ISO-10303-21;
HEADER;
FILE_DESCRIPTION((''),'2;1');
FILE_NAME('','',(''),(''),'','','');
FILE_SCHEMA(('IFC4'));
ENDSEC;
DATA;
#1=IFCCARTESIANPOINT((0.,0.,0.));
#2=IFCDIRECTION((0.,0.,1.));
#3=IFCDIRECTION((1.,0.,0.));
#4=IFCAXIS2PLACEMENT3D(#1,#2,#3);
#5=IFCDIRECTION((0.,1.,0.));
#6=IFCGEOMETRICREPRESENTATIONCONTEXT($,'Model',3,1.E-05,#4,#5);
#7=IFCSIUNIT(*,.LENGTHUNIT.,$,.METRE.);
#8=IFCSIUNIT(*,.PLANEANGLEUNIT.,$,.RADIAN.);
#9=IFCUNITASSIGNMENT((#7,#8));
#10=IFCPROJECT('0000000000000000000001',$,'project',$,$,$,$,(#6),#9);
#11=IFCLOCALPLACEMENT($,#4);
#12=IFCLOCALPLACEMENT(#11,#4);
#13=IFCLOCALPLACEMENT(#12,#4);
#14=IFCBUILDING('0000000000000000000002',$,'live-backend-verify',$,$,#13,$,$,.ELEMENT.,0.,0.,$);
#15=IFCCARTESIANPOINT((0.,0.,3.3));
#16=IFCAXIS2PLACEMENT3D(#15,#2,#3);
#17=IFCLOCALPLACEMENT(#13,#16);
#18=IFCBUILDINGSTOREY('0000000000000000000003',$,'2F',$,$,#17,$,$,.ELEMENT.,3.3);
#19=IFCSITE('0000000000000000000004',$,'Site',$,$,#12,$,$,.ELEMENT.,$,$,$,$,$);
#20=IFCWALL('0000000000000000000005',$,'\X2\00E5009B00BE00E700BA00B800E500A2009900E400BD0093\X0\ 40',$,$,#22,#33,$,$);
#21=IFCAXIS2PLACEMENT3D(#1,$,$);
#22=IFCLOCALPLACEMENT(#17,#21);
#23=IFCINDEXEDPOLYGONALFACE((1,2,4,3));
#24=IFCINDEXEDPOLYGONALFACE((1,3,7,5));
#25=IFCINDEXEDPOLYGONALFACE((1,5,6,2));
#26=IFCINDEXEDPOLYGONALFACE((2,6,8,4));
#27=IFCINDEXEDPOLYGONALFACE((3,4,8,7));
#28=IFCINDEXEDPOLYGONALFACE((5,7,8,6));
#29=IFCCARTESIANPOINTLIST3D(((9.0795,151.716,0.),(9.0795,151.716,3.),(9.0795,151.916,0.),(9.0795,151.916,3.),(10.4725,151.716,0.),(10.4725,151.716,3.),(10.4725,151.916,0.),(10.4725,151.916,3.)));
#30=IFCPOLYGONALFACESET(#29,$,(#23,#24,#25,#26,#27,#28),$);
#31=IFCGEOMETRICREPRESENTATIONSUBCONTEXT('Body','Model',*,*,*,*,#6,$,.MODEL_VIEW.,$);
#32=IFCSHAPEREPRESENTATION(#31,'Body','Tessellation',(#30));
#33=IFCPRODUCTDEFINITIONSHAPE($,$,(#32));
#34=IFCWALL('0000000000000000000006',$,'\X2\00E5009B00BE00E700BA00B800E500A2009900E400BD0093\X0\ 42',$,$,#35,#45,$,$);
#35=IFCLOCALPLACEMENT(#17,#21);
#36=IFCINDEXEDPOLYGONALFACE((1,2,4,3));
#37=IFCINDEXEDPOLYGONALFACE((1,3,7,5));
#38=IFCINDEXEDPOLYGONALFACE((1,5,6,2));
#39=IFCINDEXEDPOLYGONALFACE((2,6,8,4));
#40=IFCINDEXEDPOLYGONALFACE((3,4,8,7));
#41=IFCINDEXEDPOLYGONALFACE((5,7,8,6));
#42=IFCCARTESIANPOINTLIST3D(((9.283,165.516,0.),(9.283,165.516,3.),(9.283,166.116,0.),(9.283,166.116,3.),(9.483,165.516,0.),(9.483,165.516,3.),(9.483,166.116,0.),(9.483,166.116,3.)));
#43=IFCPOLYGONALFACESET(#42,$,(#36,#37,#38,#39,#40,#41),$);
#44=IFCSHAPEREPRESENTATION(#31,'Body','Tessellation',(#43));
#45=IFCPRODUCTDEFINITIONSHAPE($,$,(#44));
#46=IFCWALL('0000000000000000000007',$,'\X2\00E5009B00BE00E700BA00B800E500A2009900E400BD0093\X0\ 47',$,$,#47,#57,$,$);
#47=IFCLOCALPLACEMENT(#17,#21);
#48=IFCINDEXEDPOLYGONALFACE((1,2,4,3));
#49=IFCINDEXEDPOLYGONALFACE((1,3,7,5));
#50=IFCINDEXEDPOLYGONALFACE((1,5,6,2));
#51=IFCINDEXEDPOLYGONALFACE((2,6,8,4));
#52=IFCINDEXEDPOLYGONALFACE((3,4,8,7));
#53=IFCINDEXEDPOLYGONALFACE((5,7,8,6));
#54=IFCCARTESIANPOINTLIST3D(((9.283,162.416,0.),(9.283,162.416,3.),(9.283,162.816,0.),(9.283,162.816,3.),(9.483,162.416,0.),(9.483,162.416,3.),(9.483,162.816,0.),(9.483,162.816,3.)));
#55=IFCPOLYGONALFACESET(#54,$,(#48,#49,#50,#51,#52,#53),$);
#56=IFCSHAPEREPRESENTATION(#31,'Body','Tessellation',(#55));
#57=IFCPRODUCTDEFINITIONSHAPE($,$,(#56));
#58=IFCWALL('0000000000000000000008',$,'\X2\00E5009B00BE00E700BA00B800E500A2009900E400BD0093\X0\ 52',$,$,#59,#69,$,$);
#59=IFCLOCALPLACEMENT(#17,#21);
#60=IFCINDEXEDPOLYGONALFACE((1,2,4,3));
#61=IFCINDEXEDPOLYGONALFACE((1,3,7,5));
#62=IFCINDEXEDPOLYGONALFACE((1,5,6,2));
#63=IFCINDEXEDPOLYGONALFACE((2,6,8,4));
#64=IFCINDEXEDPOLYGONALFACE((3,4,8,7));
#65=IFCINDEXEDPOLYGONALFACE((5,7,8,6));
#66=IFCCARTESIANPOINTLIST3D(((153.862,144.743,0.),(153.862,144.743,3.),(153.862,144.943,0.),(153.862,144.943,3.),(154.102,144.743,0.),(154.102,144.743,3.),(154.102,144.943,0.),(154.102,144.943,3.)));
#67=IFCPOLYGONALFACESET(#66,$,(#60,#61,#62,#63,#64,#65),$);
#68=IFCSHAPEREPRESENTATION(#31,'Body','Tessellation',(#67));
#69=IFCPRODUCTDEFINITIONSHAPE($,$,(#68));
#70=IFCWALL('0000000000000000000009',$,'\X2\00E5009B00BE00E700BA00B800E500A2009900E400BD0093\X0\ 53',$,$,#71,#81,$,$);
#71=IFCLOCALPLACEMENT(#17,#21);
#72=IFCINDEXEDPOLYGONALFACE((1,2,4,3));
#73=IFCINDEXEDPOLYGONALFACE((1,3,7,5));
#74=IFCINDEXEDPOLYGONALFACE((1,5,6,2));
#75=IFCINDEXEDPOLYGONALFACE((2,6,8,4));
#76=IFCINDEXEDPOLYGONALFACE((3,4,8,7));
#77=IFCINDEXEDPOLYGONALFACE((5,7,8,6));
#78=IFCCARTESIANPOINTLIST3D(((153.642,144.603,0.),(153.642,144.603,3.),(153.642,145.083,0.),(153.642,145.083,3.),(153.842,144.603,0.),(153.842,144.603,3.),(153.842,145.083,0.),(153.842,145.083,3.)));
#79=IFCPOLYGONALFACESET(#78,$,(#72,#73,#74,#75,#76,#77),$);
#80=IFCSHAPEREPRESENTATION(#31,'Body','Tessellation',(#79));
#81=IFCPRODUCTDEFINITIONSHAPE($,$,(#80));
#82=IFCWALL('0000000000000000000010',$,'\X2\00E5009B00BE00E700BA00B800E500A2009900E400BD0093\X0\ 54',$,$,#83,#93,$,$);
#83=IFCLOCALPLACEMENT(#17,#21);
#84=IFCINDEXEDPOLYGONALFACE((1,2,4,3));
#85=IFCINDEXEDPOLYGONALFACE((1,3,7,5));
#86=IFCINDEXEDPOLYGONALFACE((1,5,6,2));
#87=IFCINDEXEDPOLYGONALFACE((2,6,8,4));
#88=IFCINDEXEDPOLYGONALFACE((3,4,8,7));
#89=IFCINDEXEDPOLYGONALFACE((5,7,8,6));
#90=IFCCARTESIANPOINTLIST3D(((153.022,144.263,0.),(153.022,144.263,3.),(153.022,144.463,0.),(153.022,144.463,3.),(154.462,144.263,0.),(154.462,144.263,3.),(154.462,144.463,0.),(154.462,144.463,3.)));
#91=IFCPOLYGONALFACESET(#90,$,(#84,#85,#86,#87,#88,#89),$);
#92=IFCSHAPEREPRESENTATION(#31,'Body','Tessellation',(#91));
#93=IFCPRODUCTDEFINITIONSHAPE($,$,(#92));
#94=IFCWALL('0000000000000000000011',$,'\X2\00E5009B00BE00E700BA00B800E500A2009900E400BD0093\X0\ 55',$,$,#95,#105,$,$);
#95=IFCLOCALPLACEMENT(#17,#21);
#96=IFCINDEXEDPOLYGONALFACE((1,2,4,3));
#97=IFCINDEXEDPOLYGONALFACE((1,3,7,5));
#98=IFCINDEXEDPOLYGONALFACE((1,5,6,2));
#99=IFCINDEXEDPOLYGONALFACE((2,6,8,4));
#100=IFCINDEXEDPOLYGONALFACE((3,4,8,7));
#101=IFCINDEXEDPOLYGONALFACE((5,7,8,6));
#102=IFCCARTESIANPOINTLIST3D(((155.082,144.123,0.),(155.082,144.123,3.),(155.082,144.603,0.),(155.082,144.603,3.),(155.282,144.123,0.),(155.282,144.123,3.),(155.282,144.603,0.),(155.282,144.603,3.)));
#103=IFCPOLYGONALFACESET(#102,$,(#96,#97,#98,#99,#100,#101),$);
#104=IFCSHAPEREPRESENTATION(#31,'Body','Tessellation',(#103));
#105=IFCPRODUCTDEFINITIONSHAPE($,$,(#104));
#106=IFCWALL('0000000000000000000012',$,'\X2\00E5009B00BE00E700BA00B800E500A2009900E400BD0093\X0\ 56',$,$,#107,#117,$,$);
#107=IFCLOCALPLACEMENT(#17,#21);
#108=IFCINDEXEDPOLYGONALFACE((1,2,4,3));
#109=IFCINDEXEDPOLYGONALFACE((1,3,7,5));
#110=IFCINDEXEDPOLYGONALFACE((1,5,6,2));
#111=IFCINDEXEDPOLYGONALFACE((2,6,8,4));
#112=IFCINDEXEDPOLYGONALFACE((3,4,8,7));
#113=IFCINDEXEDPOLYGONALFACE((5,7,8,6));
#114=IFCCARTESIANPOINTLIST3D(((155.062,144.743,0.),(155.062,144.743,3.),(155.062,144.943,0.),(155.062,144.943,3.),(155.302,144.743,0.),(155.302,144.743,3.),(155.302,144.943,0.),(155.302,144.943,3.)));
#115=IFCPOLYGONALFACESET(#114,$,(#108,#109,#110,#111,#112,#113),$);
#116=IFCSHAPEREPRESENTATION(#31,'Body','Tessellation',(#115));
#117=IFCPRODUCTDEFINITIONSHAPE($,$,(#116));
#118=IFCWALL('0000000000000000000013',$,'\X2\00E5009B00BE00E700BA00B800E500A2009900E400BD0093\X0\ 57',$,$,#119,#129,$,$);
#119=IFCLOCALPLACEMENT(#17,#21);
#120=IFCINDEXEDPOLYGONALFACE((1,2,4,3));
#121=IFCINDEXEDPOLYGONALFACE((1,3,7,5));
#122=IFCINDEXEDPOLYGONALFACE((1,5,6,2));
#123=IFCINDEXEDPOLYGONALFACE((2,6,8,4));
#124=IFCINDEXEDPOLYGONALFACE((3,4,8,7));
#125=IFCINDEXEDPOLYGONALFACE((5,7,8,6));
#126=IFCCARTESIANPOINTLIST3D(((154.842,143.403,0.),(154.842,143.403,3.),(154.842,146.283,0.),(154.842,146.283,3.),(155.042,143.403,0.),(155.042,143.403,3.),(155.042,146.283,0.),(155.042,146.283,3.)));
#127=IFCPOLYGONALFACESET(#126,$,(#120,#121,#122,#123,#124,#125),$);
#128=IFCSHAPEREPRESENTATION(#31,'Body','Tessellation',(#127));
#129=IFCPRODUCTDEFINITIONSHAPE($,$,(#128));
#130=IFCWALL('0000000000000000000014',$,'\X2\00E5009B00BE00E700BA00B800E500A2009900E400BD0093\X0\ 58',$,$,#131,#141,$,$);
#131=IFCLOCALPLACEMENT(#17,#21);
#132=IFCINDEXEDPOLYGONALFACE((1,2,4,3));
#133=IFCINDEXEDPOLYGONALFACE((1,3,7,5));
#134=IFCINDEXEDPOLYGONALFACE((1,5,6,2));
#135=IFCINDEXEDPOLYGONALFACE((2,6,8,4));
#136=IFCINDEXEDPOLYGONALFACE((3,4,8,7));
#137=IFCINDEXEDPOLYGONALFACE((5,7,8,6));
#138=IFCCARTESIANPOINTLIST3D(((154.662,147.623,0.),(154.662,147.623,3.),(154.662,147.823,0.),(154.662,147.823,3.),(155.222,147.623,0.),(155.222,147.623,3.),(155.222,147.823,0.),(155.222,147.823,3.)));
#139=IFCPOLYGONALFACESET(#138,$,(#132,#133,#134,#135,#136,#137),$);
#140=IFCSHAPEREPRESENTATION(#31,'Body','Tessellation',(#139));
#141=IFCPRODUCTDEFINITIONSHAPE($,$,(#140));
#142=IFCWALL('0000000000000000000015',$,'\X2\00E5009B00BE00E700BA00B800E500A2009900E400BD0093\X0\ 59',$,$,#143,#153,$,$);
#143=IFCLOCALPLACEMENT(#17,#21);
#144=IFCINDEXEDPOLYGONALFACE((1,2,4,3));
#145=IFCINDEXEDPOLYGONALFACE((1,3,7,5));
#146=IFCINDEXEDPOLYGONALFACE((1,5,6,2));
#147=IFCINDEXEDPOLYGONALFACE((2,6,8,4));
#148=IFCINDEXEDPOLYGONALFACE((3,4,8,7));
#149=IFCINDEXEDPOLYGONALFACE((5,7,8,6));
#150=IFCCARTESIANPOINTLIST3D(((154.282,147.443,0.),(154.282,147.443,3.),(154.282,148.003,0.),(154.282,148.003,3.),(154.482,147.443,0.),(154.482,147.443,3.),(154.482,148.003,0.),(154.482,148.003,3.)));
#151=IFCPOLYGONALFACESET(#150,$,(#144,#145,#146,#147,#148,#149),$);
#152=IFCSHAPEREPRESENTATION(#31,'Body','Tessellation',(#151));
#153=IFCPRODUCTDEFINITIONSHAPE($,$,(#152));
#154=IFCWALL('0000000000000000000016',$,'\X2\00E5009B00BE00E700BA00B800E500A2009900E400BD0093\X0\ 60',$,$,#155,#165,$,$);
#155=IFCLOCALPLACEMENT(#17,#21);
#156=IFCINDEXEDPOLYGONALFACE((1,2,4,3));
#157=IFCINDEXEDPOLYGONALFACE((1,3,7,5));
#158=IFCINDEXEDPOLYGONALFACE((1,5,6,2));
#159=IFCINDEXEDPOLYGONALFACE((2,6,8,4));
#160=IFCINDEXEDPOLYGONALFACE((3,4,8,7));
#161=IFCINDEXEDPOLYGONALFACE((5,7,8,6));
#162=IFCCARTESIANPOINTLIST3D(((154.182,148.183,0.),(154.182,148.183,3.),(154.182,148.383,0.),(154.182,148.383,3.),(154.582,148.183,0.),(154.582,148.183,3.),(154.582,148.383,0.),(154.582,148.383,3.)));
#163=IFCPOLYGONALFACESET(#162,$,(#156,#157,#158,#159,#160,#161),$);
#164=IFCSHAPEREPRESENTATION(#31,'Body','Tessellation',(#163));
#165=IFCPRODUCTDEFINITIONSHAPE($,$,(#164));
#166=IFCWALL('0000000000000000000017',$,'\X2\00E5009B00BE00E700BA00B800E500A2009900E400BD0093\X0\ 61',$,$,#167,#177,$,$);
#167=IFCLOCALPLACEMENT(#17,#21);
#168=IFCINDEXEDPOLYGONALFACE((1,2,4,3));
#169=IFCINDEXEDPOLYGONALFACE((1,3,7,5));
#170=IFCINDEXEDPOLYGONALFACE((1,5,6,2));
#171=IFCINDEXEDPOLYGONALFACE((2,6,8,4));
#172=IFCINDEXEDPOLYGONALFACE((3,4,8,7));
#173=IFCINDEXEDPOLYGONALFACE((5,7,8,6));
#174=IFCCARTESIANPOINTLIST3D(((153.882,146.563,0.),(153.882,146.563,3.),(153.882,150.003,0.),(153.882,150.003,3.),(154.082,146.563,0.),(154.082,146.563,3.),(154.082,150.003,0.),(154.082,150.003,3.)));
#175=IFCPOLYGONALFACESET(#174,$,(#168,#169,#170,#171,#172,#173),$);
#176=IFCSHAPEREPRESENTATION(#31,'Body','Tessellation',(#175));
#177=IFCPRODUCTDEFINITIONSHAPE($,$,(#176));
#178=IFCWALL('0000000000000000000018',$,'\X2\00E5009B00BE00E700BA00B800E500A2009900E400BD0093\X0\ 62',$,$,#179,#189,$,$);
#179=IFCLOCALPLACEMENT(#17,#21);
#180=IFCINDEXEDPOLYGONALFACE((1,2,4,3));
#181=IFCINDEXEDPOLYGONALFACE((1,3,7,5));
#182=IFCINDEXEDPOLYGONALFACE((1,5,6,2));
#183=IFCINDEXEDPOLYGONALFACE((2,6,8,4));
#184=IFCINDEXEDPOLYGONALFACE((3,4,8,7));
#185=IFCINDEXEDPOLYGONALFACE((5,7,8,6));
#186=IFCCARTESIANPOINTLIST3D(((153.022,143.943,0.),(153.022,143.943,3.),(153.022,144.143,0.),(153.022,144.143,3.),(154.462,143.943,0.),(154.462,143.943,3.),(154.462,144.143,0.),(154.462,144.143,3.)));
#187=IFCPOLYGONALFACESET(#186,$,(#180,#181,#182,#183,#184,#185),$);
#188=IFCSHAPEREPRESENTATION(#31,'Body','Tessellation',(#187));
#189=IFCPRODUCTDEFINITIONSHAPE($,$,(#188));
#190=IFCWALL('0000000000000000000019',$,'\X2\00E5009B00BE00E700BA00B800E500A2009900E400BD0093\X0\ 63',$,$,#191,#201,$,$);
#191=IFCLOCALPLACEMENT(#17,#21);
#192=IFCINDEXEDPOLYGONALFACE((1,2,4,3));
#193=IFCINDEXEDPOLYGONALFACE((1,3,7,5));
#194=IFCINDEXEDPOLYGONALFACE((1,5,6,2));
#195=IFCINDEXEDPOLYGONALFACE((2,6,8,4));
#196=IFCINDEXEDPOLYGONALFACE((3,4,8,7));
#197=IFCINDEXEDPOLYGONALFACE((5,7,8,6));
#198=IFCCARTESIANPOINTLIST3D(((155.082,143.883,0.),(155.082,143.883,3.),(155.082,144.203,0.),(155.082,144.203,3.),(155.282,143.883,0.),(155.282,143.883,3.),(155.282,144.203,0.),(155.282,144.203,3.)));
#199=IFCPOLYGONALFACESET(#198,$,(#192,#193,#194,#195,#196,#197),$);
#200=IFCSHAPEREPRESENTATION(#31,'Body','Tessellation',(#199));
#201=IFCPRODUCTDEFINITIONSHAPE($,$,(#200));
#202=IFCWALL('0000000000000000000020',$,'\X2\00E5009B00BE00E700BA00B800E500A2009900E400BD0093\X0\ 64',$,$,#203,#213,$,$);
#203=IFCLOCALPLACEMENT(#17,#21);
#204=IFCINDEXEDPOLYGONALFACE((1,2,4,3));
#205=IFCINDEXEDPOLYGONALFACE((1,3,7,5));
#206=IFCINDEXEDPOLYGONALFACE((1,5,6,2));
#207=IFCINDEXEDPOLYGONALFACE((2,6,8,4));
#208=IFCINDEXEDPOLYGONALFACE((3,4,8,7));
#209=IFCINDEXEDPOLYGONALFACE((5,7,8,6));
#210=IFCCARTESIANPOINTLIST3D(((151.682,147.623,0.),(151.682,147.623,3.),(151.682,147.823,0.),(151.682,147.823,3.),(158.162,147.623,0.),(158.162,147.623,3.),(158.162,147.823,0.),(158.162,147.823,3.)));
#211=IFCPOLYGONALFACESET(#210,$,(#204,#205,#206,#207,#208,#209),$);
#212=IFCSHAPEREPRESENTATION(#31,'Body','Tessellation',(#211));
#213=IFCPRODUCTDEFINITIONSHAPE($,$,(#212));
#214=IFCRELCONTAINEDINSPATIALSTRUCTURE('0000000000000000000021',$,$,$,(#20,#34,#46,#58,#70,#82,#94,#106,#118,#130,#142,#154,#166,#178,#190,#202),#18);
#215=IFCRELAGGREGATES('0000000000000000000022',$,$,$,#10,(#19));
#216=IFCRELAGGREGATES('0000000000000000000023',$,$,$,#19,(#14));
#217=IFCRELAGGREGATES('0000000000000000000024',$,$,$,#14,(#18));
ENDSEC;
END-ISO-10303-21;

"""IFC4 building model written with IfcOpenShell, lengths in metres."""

from ifc_helpers import new_model, si_unit, direction, frame, frame_2d, origin_with_axes, place, context, subcontext, project, spatial, rectangle, extrude, element, save


model = new_model("IFC4")

# Units and contexts
model_context = context("Model", 3, precision=1e-05, world=origin_with_axes(), true_north=direction((0.0, 1.0, 0.0)))
body_context = subcontext(model_context, "Body", "Model", "MODEL_VIEW")
ifc_project = project(units=[si_unit("LENGTHUNIT", "METRE"), si_unit("PLANEANGLEUNIT", "RADIAN")], contexts=[model_context])

# Site, building, storey
placement = place(None, origin_with_axes())
site_placement = place(placement, origin_with_axes())
site = spatial("IfcSite", under=ifc_project, at=site_placement, Name="Site", CompositionType="ELEMENT")
building_placement = place(site_placement, origin_with_axes())
building = spatial("IfcBuilding", under=site, at=building_placement, Name="live-backend-verify", CompositionType="ELEMENT", ElevationOfRefHeight=0.0, ElevationOfTerrain=0.0)
storey_placement = place(building_placement, frame((0.0, 0.0, 3.3), z_axis=(0.0, 0.0, 1.0), x_axis=(1.0, 0.0, 0.0)))
storey = spatial("IfcBuildingStorey", under=building, at=storey_placement, Name="2F", CompositionType="ELEMENT", Elevation=3.3)

# Walls
wall_1_placement = place(storey_placement, frame((9.776, 151.816, 0.0), z_axis=(0.0, 0.0, 1.0), x_axis=(-1.0, 0.0, 0.0)))
element("IfcWall", 1, at=wall_1_placement, inside=storey, Name="å\u009b¾çº¸å¢\u0099ä½\u0093 40", context=body_context, shape_type="SweptSolid", body=[
    extrude(rectangle(XDim=1.393, YDim=0.2, at=frame_2d((0.0, 0.0), x_axis=(1.0, 0.0, 0.0))), frame((0.0, 0.0, 0.0), z_axis=(0.0, 0.0, 1.0)), (0.0, 0.0, 1.0), 3.0),
])
wall_2_placement = place(storey_placement, frame((9.383, 165.816, 0.0), z_axis=(0.0, 0.0, 1.0), x_axis=(0.0, 1.0, 0.0)))
element("IfcWall", 2, at=wall_2_placement, inside=storey, Name="å\u009b¾çº¸å¢\u0099ä½\u0093 42", context=body_context, shape_type="SweptSolid", body=[
    extrude(rectangle(XDim=0.6, YDim=0.2, at=frame_2d((0.0, 0.0), x_axis=(1.0, 0.0, 0.0))), frame((0.0, 0.0, 0.0), z_axis=(0.0, 0.0, 1.0)), (0.0, 0.0, 1.0), 3.0),
])
wall_3_placement = place(storey_placement, frame((9.383, 162.616, 0.0), z_axis=(0.0, 0.0, 1.0), x_axis=(0.0, -1.0, 0.0)))
element("IfcWall", 3, at=wall_3_placement, inside=storey, Name="å\u009b¾çº¸å¢\u0099ä½\u0093 47", context=body_context, shape_type="SweptSolid", body=[
    extrude(rectangle(XDim=0.4, YDim=0.2, at=frame_2d((0.0, 0.0), x_axis=(1.0, 0.0, 0.0))), frame((0.0, 0.0, 0.0), z_axis=(0.0, 0.0, 1.0)), (0.0, 0.0, 1.0), 3.0),
])
wall_4_placement = place(storey_placement, frame((153.982, 144.843, 0.0), z_axis=(0.0, 0.0, 1.0), x_axis=(-1.0, 0.0, 0.0)))
element("IfcWall", 4, at=wall_4_placement, inside=storey, Name="å\u009b¾çº¸å¢\u0099ä½\u0093 52", context=body_context, shape_type="SweptSolid", body=[
    extrude(rectangle(XDim=0.24, YDim=0.2, at=frame_2d((0.0, 0.0), x_axis=(1.0, 0.0, 0.0))), frame((0.0, 0.0, 0.0), z_axis=(0.0, 0.0, 1.0)), (0.0, 0.0, 1.0), 3.0),
])
wall_5_placement = place(storey_placement, frame((153.742, 144.843, 0.0), z_axis=(0.0, 0.0, 1.0), x_axis=(0.0, -1.0, 0.0)))
element("IfcWall", 5, at=wall_5_placement, inside=storey, Name="å\u009b¾çº¸å¢\u0099ä½\u0093 53", context=body_context, shape_type="SweptSolid", body=[
    extrude(rectangle(XDim=0.48, YDim=0.2, at=frame_2d((0.0, 0.0), x_axis=(1.0, 0.0, 0.0))), frame((0.0, 0.0, 0.0), z_axis=(0.0, 0.0, 1.0)), (0.0, 0.0, 1.0), 3.0),
])
wall_6_placement = place(storey_placement, frame((153.742, 144.363, 0.0), z_axis=(0.0, 0.0, 1.0), x_axis=(1.0, 0.0, 0.0)))
element("IfcWall", 6, at=wall_6_placement, inside=storey, Name="å\u009b¾çº¸å¢\u0099ä½\u0093 54", context=body_context, shape_type="SweptSolid", body=[
    extrude(rectangle(XDim=1.44, YDim=0.2, at=frame_2d((0.0, 0.0), x_axis=(1.0, 0.0, 0.0))), frame((0.0, 0.0, 0.0), z_axis=(0.0, 0.0, 1.0)), (0.0, 0.0, 1.0), 3.0),
])
wall_7_placement = place(storey_placement, frame((155.182, 144.363, 0.0), z_axis=(0.0, 0.0, 1.0), x_axis=(0.0, 1.0, 0.0)))
element("IfcWall", 7, at=wall_7_placement, inside=storey, Name="å\u009b¾çº¸å¢\u0099ä½\u0093 55", context=body_context, shape_type="SweptSolid", body=[
    extrude(rectangle(XDim=0.48, YDim=0.2, at=frame_2d((0.0, 0.0), x_axis=(1.0, 0.0, 0.0))), frame((0.0, 0.0, 0.0), z_axis=(0.0, 0.0, 1.0)), (0.0, 0.0, 1.0), 3.0),
])
wall_8_placement = place(storey_placement, frame((155.182, 144.843, 0.0), z_axis=(0.0, 0.0, 1.0), x_axis=(-1.0, 0.0, 0.0)))
element("IfcWall", 8, at=wall_8_placement, inside=storey, Name="å\u009b¾çº¸å¢\u0099ä½\u0093 56", context=body_context, shape_type="SweptSolid", body=[
    extrude(rectangle(XDim=0.24, YDim=0.2, at=frame_2d((0.0, 0.0), x_axis=(1.0, 0.0, 0.0))), frame((0.0, 0.0, 0.0), z_axis=(0.0, 0.0, 1.0)), (0.0, 0.0, 1.0), 3.0),
])
wall_9_placement = place(storey_placement, frame((154.942, 144.843, 0.0), z_axis=(0.0, 0.0, 1.0), x_axis=(0.0, 1.0, 0.0)))
element("IfcWall", 9, at=wall_9_placement, inside=storey, Name="å\u009b¾çº¸å¢\u0099ä½\u0093 57", context=body_context, shape_type="SweptSolid", body=[
    extrude(rectangle(XDim=2.88, YDim=0.2, at=frame_2d((0.0, 0.0), x_axis=(1.0, 0.0, 0.0))), frame((0.0, 0.0, 0.0), z_axis=(0.0, 0.0, 1.0)), (0.0, 0.0, 1.0), 3.0),
])
for number, where, z_axis, x_axis, name in (
    (10, (154.942, 147.723, 0.0), (0.0, 0.0, 1.0), (-1.0, 0.0, 0.0), "å\u009b¾çº¸å¢\u0099ä½\u0093 58"),
    (11, (154.382, 147.723, 0.0), (0.0, 0.0, 1.0), (0.0, 1.0, 0.0), "å\u009b¾çº¸å¢\u0099ä½\u0093 59"),
):
    element("IfcWall", number, at=place(storey_placement, frame(where, z_axis=z_axis, x_axis=x_axis)), inside=storey, Name=name, context=body_context, shape_type="SweptSolid", body=[
        extrude(rectangle(XDim=0.56, YDim=0.2, at=frame_2d((0.0, 0.0), x_axis=(1.0, 0.0, 0.0))), frame((0.0, 0.0, 0.0), z_axis=(0.0, 0.0, 1.0)), (0.0, 0.0, 1.0), 3.0),
    ])
wall_10_placement = place(storey_placement, frame((154.382, 148.283, 0.0), z_axis=(0.0, 0.0, 1.0), x_axis=(-1.0, 0.0, 0.0)))
element("IfcWall", 12, at=wall_10_placement, inside=storey, Name="å\u009b¾çº¸å¢\u0099ä½\u0093 60", context=body_context, shape_type="SweptSolid", body=[
    extrude(rectangle(XDim=0.4, YDim=0.2, at=frame_2d((0.0, 0.0), x_axis=(1.0, 0.0, 0.0))), frame((0.0, 0.0, 0.0), z_axis=(0.0, 0.0, 1.0)), (0.0, 0.0, 1.0), 3.0),
])
wall_11_placement = place(storey_placement, frame((153.982, 148.283, 0.0), z_axis=(0.0, 0.0, 1.0), x_axis=(0.0, -1.0, 0.0)))
element("IfcWall", 13, at=wall_11_placement, inside=storey, Name="å\u009b¾çº¸å¢\u0099ä½\u0093 61", context=body_context, shape_type="SweptSolid", body=[
    extrude(rectangle(XDim=3.44, YDim=0.2, at=frame_2d((0.0, 0.0), x_axis=(1.0, 0.0, 0.0))), frame((0.0, 0.0, 0.0), z_axis=(0.0, 0.0, 1.0)), (0.0, 0.0, 1.0), 3.0),
])
wall_12_placement = place(storey_placement, frame((153.742, 144.043, 0.0), z_axis=(0.0, 0.0, 1.0), x_axis=(1.0, 0.0, 0.0)))
element("IfcWall", 14, at=wall_12_placement, inside=storey, Name="å\u009b¾çº¸å¢\u0099ä½\u0093 62", context=body_context, shape_type="SweptSolid", body=[
    extrude(rectangle(XDim=1.44, YDim=0.2, at=frame_2d((0.0, 0.0), x_axis=(1.0, 0.0, 0.0))), frame((0.0, 0.0, 0.0), z_axis=(0.0, 0.0, 1.0)), (0.0, 0.0, 1.0), 3.0),
])
wall_13_placement = place(storey_placement, frame((155.182, 144.043, 0.0), z_axis=(0.0, 0.0, 1.0), x_axis=(0.0, 1.0, 0.0)))
element("IfcWall", 15, at=wall_13_placement, inside=storey, Name="å\u009b¾çº¸å¢\u0099ä½\u0093 63", context=body_context, shape_type="SweptSolid", body=[
    extrude(rectangle(XDim=0.32, YDim=0.2, at=frame_2d((0.0, 0.0), x_axis=(1.0, 0.0, 0.0))), frame((0.0, 0.0, 0.0), z_axis=(0.0, 0.0, 1.0)), (0.0, 0.0, 1.0), 3.0),
])
wall_14_placement = place(storey_placement, frame((154.922, 147.723, 0.0), z_axis=(0.0, 0.0, 1.0), x_axis=(1.0, 0.0, 0.0)))
element("IfcWall", 16, at=wall_14_placement, inside=storey, Name="å\u009b¾çº¸å¢\u0099ä½\u0093 64", context=body_context, shape_type="SweptSolid", body=[
    extrude(rectangle(XDim=6.48, YDim=0.2, at=frame_2d((0.0, 0.0), x_axis=(1.0, 0.0, 0.0))), frame((0.0, 0.0, 0.0), z_axis=(0.0, 0.0, 1.0)), (0.0, 0.0, 1.0), 3.0),
])

save(model, "model.ifc")
